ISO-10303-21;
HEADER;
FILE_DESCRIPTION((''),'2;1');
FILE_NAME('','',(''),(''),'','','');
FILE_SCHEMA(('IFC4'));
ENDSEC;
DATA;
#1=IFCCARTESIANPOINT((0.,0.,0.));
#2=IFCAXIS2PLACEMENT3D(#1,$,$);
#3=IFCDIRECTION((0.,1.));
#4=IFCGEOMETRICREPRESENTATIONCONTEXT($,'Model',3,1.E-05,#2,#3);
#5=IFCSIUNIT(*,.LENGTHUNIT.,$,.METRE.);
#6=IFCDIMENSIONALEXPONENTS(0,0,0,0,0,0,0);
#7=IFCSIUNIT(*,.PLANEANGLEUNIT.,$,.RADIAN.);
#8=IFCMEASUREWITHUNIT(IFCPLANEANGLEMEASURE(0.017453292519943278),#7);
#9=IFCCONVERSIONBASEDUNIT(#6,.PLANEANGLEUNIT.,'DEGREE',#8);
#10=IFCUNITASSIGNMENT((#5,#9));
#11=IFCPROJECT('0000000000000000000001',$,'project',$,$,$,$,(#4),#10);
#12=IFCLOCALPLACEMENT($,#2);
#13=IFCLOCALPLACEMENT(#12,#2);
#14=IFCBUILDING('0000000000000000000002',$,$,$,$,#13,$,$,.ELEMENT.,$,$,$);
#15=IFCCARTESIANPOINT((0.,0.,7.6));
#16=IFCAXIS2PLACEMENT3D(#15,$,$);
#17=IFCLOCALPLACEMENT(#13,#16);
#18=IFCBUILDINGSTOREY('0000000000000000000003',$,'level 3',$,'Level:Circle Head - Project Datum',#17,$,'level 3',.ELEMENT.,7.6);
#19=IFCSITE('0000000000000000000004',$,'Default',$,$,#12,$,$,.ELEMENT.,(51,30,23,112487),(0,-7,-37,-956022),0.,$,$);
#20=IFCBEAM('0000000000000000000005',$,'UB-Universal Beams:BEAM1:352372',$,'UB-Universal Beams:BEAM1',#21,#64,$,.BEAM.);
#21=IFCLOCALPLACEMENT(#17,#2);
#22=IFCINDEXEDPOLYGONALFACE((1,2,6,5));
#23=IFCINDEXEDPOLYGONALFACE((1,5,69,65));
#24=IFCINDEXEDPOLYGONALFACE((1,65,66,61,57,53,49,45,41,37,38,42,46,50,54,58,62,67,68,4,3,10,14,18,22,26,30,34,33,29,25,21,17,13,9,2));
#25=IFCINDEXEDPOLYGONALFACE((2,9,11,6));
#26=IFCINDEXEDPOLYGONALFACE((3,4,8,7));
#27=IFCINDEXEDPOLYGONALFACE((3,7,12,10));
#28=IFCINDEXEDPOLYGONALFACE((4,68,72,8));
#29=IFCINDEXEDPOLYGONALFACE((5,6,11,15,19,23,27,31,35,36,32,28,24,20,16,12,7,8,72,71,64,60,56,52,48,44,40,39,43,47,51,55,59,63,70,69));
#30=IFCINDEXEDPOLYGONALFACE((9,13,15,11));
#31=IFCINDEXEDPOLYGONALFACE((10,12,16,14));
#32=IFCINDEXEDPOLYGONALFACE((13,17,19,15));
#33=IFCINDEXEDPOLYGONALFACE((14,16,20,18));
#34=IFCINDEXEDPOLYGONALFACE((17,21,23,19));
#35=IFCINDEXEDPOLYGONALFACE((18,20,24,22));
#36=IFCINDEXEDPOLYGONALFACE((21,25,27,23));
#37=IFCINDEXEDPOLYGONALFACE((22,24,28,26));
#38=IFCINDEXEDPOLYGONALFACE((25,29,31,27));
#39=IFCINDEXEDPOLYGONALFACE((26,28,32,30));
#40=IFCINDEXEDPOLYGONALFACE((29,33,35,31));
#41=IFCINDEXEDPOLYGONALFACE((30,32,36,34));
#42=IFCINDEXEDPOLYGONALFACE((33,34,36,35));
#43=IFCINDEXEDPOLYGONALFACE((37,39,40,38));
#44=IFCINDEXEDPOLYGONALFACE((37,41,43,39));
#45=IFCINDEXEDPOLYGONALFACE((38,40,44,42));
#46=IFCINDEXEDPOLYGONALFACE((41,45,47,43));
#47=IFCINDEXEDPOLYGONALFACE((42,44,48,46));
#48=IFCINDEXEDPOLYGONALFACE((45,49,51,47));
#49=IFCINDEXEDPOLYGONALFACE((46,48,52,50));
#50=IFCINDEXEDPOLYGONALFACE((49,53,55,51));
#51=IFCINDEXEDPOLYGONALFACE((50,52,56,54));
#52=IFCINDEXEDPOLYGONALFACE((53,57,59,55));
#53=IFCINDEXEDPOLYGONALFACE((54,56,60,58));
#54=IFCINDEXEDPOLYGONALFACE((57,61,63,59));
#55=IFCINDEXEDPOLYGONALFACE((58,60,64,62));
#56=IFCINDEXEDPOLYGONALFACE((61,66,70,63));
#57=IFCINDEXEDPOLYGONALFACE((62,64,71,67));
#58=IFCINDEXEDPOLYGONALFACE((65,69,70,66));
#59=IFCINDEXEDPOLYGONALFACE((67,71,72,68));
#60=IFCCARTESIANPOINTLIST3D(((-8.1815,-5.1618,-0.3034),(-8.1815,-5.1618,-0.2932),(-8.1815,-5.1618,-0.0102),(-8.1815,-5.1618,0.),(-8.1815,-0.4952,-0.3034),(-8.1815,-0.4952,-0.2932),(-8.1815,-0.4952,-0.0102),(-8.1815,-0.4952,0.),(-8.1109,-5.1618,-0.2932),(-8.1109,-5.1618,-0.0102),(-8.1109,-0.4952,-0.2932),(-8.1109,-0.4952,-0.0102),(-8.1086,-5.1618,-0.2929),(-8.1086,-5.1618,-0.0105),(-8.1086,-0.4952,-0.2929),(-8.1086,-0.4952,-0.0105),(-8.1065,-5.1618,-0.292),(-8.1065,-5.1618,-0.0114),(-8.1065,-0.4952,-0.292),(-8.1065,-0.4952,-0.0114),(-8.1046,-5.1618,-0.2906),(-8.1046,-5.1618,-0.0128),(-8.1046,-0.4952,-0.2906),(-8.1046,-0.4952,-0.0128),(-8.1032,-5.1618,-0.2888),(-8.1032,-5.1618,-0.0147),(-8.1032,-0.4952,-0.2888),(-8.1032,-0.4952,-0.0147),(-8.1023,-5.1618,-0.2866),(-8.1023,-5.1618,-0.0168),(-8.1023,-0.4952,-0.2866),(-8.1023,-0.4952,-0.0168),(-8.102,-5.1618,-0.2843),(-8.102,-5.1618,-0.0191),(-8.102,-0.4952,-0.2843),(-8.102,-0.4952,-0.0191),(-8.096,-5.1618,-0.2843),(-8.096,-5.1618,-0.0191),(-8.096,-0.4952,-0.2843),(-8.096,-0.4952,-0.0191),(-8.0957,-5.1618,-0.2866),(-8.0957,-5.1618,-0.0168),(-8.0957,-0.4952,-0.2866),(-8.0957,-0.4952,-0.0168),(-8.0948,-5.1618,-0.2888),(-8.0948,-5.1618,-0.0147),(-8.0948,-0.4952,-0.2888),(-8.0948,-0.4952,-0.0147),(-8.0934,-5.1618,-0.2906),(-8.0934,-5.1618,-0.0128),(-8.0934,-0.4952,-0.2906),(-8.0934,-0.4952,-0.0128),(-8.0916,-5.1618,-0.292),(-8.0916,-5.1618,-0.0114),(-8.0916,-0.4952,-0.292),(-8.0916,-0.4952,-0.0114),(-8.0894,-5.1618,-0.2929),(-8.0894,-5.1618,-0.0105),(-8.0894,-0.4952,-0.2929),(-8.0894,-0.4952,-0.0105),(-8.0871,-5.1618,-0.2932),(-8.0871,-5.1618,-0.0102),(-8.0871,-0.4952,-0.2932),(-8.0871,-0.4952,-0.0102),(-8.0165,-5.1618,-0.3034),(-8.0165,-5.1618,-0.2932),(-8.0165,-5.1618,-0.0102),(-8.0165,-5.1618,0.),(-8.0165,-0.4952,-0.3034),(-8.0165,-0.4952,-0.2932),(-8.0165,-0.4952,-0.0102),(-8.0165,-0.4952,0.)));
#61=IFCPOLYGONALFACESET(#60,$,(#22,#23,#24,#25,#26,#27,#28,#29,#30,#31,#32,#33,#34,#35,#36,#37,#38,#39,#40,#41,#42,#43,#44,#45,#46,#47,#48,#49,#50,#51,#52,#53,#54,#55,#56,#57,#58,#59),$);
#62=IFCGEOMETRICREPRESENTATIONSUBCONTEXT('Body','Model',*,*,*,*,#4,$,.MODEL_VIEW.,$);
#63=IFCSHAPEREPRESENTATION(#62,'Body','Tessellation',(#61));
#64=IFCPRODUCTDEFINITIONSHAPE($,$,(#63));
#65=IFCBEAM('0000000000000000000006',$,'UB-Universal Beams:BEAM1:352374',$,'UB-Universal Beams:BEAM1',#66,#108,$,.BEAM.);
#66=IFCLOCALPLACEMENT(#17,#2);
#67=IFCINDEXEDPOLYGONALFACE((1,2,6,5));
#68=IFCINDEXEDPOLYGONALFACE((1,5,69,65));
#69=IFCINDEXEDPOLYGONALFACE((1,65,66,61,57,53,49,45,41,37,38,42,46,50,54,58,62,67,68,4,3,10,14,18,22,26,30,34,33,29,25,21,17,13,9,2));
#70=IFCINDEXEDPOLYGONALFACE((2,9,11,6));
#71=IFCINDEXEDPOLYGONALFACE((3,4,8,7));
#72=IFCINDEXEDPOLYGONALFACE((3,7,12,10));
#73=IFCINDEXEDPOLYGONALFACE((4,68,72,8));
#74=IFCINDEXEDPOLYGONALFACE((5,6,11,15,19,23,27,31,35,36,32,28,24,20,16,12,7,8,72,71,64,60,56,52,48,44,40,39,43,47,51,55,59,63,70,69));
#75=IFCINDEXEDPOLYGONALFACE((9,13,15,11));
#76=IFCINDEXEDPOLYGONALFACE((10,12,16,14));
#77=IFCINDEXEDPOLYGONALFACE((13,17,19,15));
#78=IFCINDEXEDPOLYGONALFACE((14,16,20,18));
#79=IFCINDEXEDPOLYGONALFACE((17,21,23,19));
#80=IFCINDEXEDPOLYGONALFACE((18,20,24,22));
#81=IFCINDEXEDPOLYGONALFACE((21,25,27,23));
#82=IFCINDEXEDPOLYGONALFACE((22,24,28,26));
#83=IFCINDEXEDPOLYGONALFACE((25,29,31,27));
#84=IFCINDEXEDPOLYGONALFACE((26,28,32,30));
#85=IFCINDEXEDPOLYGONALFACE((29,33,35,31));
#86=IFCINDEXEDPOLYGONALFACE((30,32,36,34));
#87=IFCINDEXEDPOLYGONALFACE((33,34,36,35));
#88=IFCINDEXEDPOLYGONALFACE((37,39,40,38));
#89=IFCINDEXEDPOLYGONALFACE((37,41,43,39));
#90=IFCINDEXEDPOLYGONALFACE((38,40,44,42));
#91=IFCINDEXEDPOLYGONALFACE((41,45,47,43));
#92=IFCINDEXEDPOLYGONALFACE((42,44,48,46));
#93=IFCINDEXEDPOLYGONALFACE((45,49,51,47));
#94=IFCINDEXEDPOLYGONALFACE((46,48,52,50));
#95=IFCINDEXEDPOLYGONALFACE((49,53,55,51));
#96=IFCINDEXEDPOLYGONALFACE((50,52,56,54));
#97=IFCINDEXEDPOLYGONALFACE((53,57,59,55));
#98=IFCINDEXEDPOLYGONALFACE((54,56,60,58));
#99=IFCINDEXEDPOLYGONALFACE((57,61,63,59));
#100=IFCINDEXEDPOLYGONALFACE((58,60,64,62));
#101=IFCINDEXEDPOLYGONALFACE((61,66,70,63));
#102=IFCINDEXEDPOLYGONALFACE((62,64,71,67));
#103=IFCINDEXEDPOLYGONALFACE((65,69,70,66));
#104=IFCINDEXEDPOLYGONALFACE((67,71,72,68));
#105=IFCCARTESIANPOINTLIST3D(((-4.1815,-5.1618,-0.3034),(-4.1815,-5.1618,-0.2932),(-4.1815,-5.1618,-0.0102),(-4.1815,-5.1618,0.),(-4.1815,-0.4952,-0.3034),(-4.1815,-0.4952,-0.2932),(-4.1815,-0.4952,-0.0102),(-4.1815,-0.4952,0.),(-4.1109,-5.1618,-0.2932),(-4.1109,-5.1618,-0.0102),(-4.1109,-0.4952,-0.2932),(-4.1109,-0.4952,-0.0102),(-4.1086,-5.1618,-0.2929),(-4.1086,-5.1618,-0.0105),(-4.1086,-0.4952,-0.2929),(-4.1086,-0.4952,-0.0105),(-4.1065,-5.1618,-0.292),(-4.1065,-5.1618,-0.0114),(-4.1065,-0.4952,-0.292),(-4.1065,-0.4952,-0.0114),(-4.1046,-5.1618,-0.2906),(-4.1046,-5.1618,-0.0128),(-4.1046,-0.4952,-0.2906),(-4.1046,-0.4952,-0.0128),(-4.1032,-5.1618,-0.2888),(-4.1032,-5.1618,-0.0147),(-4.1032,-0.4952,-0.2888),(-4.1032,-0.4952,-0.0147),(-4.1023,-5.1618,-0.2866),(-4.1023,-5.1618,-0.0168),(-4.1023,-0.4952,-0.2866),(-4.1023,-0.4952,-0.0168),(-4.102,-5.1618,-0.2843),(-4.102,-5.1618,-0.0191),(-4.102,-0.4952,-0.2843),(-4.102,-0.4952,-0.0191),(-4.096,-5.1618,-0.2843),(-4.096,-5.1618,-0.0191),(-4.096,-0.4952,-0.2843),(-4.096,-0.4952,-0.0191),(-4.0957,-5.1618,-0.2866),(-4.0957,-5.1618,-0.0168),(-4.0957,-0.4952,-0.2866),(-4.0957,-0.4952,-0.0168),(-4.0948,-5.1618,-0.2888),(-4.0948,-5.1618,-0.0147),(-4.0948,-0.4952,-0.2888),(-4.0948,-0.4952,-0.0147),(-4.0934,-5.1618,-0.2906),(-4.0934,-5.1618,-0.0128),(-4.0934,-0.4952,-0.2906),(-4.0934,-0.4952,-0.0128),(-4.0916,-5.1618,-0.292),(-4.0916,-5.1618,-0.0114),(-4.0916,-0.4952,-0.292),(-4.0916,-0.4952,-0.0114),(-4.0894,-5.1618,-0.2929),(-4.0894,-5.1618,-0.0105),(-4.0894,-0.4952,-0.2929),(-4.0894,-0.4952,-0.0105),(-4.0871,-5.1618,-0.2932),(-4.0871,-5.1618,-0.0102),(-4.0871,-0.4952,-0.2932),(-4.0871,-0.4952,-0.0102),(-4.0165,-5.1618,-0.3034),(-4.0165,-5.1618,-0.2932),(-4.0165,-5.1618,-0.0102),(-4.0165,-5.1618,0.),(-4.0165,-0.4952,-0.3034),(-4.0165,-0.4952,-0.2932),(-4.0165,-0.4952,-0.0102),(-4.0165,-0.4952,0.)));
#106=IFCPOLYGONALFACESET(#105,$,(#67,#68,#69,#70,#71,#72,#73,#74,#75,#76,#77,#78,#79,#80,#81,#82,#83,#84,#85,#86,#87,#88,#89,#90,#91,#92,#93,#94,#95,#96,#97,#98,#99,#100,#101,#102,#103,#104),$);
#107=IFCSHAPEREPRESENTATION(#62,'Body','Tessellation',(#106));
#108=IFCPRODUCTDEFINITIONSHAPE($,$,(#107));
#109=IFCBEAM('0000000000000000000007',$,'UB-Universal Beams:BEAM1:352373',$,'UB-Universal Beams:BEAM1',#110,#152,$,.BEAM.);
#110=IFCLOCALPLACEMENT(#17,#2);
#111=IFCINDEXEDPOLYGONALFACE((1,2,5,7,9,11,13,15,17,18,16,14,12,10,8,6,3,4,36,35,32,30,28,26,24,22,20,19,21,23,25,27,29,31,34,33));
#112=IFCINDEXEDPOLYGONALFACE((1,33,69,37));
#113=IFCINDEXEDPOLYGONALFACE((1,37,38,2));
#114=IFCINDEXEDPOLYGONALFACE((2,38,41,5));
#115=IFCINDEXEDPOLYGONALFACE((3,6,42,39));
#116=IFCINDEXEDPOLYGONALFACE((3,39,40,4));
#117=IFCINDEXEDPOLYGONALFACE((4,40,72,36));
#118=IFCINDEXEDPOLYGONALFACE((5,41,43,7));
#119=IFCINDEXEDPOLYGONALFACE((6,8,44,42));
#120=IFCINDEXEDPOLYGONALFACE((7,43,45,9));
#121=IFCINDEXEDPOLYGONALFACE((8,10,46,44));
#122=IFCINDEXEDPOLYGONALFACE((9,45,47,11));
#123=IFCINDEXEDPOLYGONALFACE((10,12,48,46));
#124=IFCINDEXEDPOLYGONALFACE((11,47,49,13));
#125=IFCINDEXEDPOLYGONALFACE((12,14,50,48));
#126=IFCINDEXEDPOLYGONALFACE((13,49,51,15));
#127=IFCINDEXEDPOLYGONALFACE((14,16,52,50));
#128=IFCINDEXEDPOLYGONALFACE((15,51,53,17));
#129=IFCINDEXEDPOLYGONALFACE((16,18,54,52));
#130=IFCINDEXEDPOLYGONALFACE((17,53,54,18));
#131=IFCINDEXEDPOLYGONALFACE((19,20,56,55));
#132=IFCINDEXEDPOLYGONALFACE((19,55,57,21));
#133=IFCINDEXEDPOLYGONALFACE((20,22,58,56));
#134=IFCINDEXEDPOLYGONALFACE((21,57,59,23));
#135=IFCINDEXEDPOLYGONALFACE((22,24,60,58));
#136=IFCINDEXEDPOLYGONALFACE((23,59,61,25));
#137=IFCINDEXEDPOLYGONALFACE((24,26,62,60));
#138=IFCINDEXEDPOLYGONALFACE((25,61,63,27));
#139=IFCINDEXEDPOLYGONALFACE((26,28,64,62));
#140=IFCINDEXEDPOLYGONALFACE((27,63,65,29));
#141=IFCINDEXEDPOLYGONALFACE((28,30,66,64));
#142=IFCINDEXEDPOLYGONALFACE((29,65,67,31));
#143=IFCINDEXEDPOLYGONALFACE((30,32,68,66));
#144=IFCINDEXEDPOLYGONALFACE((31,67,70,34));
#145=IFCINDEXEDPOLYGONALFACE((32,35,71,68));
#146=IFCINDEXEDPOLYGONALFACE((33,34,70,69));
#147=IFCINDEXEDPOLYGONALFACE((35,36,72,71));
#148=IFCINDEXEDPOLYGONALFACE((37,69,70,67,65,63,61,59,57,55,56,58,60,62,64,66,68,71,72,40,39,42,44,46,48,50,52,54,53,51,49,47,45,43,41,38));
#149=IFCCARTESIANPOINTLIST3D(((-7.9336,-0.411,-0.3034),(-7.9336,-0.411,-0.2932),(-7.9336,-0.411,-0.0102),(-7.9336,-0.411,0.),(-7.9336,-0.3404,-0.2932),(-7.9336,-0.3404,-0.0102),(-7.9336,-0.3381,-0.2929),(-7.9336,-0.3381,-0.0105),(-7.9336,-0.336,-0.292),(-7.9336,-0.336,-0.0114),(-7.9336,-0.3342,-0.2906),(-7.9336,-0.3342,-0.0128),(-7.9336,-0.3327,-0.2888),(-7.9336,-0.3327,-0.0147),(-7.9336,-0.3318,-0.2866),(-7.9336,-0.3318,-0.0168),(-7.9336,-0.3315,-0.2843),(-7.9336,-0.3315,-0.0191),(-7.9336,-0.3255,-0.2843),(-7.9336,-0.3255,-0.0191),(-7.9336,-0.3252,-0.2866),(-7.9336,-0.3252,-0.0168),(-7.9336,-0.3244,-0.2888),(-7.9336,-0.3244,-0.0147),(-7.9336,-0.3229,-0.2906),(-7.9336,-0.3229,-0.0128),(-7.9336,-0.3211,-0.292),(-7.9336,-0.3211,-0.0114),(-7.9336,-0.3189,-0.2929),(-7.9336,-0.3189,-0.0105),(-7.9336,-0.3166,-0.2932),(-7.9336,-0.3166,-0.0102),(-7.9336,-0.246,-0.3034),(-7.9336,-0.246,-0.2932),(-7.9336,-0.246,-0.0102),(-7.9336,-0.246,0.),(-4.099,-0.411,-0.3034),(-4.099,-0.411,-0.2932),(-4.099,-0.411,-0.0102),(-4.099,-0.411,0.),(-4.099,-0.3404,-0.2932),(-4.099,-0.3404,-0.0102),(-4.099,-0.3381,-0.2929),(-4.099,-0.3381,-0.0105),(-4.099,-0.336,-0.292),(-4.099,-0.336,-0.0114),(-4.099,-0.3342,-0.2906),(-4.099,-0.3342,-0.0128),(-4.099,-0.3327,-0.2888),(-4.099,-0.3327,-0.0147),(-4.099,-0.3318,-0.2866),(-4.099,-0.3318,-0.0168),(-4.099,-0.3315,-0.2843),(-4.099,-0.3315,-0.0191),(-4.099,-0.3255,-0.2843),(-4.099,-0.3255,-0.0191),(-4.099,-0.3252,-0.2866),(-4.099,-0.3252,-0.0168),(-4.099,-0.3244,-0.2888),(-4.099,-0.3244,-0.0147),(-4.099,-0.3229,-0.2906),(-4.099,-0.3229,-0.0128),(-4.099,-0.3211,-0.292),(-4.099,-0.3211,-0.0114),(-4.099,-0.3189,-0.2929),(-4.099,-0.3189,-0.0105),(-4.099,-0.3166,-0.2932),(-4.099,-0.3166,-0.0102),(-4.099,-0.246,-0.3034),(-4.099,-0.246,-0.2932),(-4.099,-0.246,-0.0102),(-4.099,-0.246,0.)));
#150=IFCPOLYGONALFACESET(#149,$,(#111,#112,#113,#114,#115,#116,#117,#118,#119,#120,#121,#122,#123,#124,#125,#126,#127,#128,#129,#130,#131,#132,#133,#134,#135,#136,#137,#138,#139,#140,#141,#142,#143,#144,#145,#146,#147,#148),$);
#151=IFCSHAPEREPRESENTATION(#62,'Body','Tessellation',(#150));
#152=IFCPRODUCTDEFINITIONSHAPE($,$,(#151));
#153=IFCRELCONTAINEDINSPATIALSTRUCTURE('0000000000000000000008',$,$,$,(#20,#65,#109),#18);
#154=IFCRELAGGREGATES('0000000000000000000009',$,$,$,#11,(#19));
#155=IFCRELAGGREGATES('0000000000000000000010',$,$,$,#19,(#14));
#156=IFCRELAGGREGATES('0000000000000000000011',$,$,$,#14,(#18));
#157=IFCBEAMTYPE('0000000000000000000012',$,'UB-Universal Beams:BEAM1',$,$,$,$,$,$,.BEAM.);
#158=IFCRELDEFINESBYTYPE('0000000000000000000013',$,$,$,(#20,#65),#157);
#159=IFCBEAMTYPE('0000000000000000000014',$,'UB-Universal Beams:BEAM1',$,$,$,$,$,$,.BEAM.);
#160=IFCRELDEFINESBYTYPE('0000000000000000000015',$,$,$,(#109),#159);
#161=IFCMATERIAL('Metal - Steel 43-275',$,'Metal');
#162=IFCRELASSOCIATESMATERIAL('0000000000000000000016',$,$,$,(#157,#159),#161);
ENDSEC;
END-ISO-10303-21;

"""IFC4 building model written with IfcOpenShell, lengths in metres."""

from ifc_helpers import new_model, entity, si_unit, converted_unit, direction, frame, frame_2d, origin, place, context, subcontext, project, spatial, polyline, circle_curve, parameter, trimmed, segment, composite_curve, outline, extrude, source, transform, mapped, material, material_profile, profile_set, type_object, type_shapes, element, save


model = new_model("IFC4")

# Units and contexts
model_context = context("Model", 3, precision=1e-05, world=origin(), true_north=direction((0.0, 1.0)))
body_context = subcontext(model_context, "Body", "Model", "MODEL_VIEW")
ifc_project = project(units=[si_unit("LENGTHUNIT", "METRE"), converted_unit("PLANEANGLEUNIT", "DEGREE", entity("IfcPlaneAngleMeasure", 0.017453292519943278), si_unit("PLANEANGLEUNIT", "RADIAN"), dimensions=[0, 0, 0, 0, 0, 0, 0])], contexts=[model_context])

# Site, building, storey
site_placement = place(None, origin())
site = spatial("IfcSite", under=ifc_project, at=site_placement, Name="Default", CompositionType="ELEMENT", RefLatitude=(51, 30, 23, 112487), RefLongitude=(0, -7, -37, -956022), RefElevation=0.0)
building_placement = place(site_placement, origin())
building = spatial("IfcBuilding", under=site, at=building_placement, CompositionType="ELEMENT")
storey_placement = place(building_placement, frame((0.0, 0.0, 7.6)))
storey = spatial("IfcBuildingStorey", under=building, at=storey_placement, Name="level 3", ObjectType="Level:Circle Head - Project Datum", LongName="level 3", CompositionType="ELEMENT", Elevation=7.6)

# Shared definitions
ifc_material_1 = material(Name="Metal - Steel 43-275", Category="Metal")

# Beams
ifc_material_profile_1 = material_profile(ifc_material_1, outline(composite_curve([segment(polyline([(-0.0825, -0.1415), (-0.0825, -0.1517)]), True, "CONTINUOUS"), segment(polyline([(-0.0825, -0.1517), (0.0825, -0.1517)]), True, "CONTINUOUS"), segment(polyline([(0.0825, -0.1517), (0.0825, -0.1415)]), True, "CONTINUOUS"), segment(polyline([(0.0825, -0.1415), (0.0119, -0.1415)]), True, "CONTINUOUS"), segment(trimmed(circle_curve(frame_2d((0.0119, -0.1326), x_axis=(1.0, 0.0)), 0.0089), [parameter(180.0)], [parameter(270.0)], True, "PARAMETER"), False, "CONTINUOUS"), segment(polyline([(0.003, -0.1326), (0.003, 0.1326)]), True, "CONTINUOUS"), segment(trimmed(circle_curve(frame_2d((0.0119, 0.1326), x_axis=(1.0, 0.0)), 0.0089), [parameter(90.0)], [parameter(180.0)], True, "PARAMETER"), False, "CONTINUOUS"), segment(polyline([(0.0119, 0.1415), (0.0825, 0.1415)]), True, "CONTINUOUS"), segment(polyline([(0.0825, 0.1415), (0.0825, 0.1517)]), True, "CONTINUOUS"), segment(polyline([(0.0825, 0.1517), (-0.0825, 0.1517)]), True, "CONTINUOUS"), segment(polyline([(-0.0825, 0.1517), (-0.0825, 0.1415)]), True, "CONTINUOUS"), segment(polyline([(-0.0825, 0.1415), (-0.0119, 0.1415)]), True, "CONTINUOUS"), segment(trimmed(circle_curve(frame_2d((-0.0119, 0.1326), x_axis=(1.0, 0.0)), 0.0089), [parameter(360.0)], [parameter(90.0)], True, "PARAMETER"), False, "CONTINUOUS"), segment(polyline([(-0.003, 0.1326), (-0.003, -0.1326)]), True, "CONTINUOUS"), segment(trimmed(circle_curve(frame_2d((-0.0119, -0.1326), x_axis=(1.0, 0.0)), 0.0089), [parameter(270.0)], [parameter(360.0)], True, "PARAMETER"), False, "CONTINUOUS"), segment(polyline([(-0.0119, -0.1415), (-0.0825, -0.1415)]), True, "CONTINUOUS")], self_intersect=False)), Name="BEAM1")
ifc_profile_set_1 = profile_set([ifc_material_profile_1], Name="BEAM1")
beam_type_1 = type_object("IfcBeamType", Name="UB-Universal Beams:BEAM1", PredefinedType="BEAM", material=ifc_profile_set_1)
shared_shape_1 = source(origin(), body_context, "Body", "SweptSolid", [
    extrude(outline(composite_curve([segment(polyline([(-0.0825, -0.1415), (-0.0825, -0.1517)]), True, "CONTINUOUS"), segment(polyline([(-0.0825, -0.1517), (0.0825, -0.1517)]), True, "CONTINUOUS"), segment(polyline([(0.0825, -0.1517), (0.0825, -0.1415)]), True, "CONTINUOUS"), segment(polyline([(0.0825, -0.1415), (0.0119, -0.1415)]), True, "CONTINUOUS"), segment(trimmed(circle_curve(frame_2d((0.0119, -0.1326), x_axis=(0.0, -1.0)), 0.0089), [parameter(270.0)], [parameter(360.0)], True, "PARAMETER"), False, "CONTINUOUS"), segment(polyline([(0.003, -0.1326), (0.003, 0.1326)]), True, "CONTINUOUS"), segment(trimmed(circle_curve(frame_2d((0.0119, 0.1326), x_axis=(-1.0, 0.0)), 0.0089), [parameter(270.0)], [parameter(360.0)], True, "PARAMETER"), False, "CONTINUOUS"), segment(polyline([(0.0119, 0.1415), (0.0825, 0.1415)]), True, "CONTINUOUS"), segment(polyline([(0.0825, 0.1415), (0.0825, 0.1517)]), True, "CONTINUOUS"), segment(polyline([(0.0825, 0.1517), (-0.0825, 0.1517)]), True, "CONTINUOUS"), segment(polyline([(-0.0825, 0.1517), (-0.0825, 0.1415)]), True, "CONTINUOUS"), segment(polyline([(-0.0825, 0.1415), (-0.0119, 0.1415)]), True, "CONTINUOUS"), segment(trimmed(circle_curve(frame_2d((-0.0119, 0.1326), x_axis=(0.0, 1.0)), 0.0089), [parameter(270.0)], [parameter(360.0)], True, "PARAMETER"), False, "CONTINUOUS"), segment(polyline([(-0.003, 0.1326), (-0.003, -0.1326)]), True, "CONTINUOUS"), segment(trimmed(circle_curve(frame_2d((-0.0119, -0.1326), x_axis=(1.0, 0.0)), 0.0089), [parameter(270.0)], [parameter(0.0)], True, "PARAMETER"), False, "CONTINUOUS"), segment(polyline([(-0.0119, -0.1415), (-0.0825, -0.1415)]), True, "CONTINUOUS")], self_intersect=False)), frame((-2.3333, 0.0, 0.0), z_axis=(-1.0, 0.0, 0.0), x_axis=(0.0, -1.0, 0.0)), (0.0, 0.0, -1.0), 4.6666),
])
type_shapes(beam_type_1, [shared_shape_1])
for number, where, z_axis, x_axis, name in (
    (1, (-8.099, -2.8285, -0.1517), (0.0, 0.0, 1.0), (0.0, 1.0, 0.0), "UB-Universal Beams:BEAM1:352372"),
    (2, (-4.099, -2.8285, -0.1517), (0.0, 0.0, 1.0), (0.0, 1.0, 0.0), "UB-Universal Beams:BEAM1:352374"),
):
    element("IfcBeam", number, at=place(storey_placement, frame(where, z_axis=z_axis, x_axis=x_axis)), inside=storey, type_object=beam_type_1, Name=name, ObjectType="UB-Universal Beams:BEAM1", PredefinedType="BEAM", context=body_context, shape_type="MappedRepresentation", body=[
        mapped(shared_shape_1, transform((0.0, 0.0, 0.0), scale=1.0)),
    ])
beam_type_2 = type_object("IfcBeamType", Name="UB-Universal Beams:BEAM1", PredefinedType="BEAM", material=ifc_profile_set_1)
shared_shape_2 = source(origin(), body_context, "Body", "SweptSolid", [
    extrude(outline(composite_curve([segment(polyline([(-0.0825, -0.1415), (-0.0825, -0.1517)]), True, "CONTINUOUS"), segment(polyline([(-0.0825, -0.1517), (0.0825, -0.1517)]), True, "CONTINUOUS"), segment(polyline([(0.0825, -0.1517), (0.0825, -0.1415)]), True, "CONTINUOUS"), segment(polyline([(0.0825, -0.1415), (0.0119, -0.1415)]), True, "CONTINUOUS"), segment(trimmed(circle_curve(frame_2d((0.0119, -0.1326), x_axis=(1.0, 0.0)), 0.0089), [parameter(180.0)], [parameter(270.0)], True, "PARAMETER"), False, "CONTINUOUS"), segment(polyline([(0.003, -0.1326), (0.003, 0.1326)]), True, "CONTINUOUS"), segment(trimmed(circle_curve(frame_2d((0.0119, 0.1326), x_axis=(1.0, 0.0)), 0.0089), [parameter(90.0)], [parameter(180.0)], True, "PARAMETER"), False, "CONTINUOUS"), segment(polyline([(0.0119, 0.1415), (0.0825, 0.1415)]), True, "CONTINUOUS"), segment(polyline([(0.0825, 0.1415), (0.0825, 0.1517)]), True, "CONTINUOUS"), segment(polyline([(0.0825, 0.1517), (-0.0825, 0.1517)]), True, "CONTINUOUS"), segment(polyline([(-0.0825, 0.1517), (-0.0825, 0.1415)]), True, "CONTINUOUS"), segment(polyline([(-0.0825, 0.1415), (-0.0119, 0.1415)]), True, "CONTINUOUS"), segment(trimmed(circle_curve(frame_2d((-0.0119, 0.1326), x_axis=(1.0, 0.0)), 0.0089), [parameter(360.0)], [parameter(90.0)], True, "PARAMETER"), False, "CONTINUOUS"), segment(polyline([(-0.003, 0.1326), (-0.003, -0.1326)]), True, "CONTINUOUS"), segment(trimmed(circle_curve(frame_2d((-0.0119, -0.1326), x_axis=(1.0, 0.0)), 0.0089), [parameter(270.0)], [parameter(360.0)], True, "PARAMETER"), False, "CONTINUOUS"), segment(polyline([(-0.0119, -0.1415), (-0.0825, -0.1415)]), True, "CONTINUOUS")], self_intersect=False)), frame((-2.0, 0.0, 0.0), z_axis=(-1.0, 0.0, 0.0), x_axis=(0.0, -1.0, 0.0)), (0.0, 0.0, -1.0), 3.8346),
])
type_shapes(beam_type_2, [shared_shape_2])
beam_1_placement = place(storey_placement, frame((-6.099, -0.3285, -0.1517), z_axis=(0.0, 0.0, 1.0), x_axis=(-1.0, 0.0, 0.0)))
element("IfcBeam", 3, at=beam_1_placement, inside=storey, type_object=beam_type_2, Name="UB-Universal Beams:BEAM1:352373", ObjectType="UB-Universal Beams:BEAM1", PredefinedType="BEAM", context=body_context, shape_type="MappedRepresentation", body=[
    mapped(shared_shape_2, transform((0.0, 0.0, 0.0), scale=1.0)),
])

save(model, "model.ifc")
